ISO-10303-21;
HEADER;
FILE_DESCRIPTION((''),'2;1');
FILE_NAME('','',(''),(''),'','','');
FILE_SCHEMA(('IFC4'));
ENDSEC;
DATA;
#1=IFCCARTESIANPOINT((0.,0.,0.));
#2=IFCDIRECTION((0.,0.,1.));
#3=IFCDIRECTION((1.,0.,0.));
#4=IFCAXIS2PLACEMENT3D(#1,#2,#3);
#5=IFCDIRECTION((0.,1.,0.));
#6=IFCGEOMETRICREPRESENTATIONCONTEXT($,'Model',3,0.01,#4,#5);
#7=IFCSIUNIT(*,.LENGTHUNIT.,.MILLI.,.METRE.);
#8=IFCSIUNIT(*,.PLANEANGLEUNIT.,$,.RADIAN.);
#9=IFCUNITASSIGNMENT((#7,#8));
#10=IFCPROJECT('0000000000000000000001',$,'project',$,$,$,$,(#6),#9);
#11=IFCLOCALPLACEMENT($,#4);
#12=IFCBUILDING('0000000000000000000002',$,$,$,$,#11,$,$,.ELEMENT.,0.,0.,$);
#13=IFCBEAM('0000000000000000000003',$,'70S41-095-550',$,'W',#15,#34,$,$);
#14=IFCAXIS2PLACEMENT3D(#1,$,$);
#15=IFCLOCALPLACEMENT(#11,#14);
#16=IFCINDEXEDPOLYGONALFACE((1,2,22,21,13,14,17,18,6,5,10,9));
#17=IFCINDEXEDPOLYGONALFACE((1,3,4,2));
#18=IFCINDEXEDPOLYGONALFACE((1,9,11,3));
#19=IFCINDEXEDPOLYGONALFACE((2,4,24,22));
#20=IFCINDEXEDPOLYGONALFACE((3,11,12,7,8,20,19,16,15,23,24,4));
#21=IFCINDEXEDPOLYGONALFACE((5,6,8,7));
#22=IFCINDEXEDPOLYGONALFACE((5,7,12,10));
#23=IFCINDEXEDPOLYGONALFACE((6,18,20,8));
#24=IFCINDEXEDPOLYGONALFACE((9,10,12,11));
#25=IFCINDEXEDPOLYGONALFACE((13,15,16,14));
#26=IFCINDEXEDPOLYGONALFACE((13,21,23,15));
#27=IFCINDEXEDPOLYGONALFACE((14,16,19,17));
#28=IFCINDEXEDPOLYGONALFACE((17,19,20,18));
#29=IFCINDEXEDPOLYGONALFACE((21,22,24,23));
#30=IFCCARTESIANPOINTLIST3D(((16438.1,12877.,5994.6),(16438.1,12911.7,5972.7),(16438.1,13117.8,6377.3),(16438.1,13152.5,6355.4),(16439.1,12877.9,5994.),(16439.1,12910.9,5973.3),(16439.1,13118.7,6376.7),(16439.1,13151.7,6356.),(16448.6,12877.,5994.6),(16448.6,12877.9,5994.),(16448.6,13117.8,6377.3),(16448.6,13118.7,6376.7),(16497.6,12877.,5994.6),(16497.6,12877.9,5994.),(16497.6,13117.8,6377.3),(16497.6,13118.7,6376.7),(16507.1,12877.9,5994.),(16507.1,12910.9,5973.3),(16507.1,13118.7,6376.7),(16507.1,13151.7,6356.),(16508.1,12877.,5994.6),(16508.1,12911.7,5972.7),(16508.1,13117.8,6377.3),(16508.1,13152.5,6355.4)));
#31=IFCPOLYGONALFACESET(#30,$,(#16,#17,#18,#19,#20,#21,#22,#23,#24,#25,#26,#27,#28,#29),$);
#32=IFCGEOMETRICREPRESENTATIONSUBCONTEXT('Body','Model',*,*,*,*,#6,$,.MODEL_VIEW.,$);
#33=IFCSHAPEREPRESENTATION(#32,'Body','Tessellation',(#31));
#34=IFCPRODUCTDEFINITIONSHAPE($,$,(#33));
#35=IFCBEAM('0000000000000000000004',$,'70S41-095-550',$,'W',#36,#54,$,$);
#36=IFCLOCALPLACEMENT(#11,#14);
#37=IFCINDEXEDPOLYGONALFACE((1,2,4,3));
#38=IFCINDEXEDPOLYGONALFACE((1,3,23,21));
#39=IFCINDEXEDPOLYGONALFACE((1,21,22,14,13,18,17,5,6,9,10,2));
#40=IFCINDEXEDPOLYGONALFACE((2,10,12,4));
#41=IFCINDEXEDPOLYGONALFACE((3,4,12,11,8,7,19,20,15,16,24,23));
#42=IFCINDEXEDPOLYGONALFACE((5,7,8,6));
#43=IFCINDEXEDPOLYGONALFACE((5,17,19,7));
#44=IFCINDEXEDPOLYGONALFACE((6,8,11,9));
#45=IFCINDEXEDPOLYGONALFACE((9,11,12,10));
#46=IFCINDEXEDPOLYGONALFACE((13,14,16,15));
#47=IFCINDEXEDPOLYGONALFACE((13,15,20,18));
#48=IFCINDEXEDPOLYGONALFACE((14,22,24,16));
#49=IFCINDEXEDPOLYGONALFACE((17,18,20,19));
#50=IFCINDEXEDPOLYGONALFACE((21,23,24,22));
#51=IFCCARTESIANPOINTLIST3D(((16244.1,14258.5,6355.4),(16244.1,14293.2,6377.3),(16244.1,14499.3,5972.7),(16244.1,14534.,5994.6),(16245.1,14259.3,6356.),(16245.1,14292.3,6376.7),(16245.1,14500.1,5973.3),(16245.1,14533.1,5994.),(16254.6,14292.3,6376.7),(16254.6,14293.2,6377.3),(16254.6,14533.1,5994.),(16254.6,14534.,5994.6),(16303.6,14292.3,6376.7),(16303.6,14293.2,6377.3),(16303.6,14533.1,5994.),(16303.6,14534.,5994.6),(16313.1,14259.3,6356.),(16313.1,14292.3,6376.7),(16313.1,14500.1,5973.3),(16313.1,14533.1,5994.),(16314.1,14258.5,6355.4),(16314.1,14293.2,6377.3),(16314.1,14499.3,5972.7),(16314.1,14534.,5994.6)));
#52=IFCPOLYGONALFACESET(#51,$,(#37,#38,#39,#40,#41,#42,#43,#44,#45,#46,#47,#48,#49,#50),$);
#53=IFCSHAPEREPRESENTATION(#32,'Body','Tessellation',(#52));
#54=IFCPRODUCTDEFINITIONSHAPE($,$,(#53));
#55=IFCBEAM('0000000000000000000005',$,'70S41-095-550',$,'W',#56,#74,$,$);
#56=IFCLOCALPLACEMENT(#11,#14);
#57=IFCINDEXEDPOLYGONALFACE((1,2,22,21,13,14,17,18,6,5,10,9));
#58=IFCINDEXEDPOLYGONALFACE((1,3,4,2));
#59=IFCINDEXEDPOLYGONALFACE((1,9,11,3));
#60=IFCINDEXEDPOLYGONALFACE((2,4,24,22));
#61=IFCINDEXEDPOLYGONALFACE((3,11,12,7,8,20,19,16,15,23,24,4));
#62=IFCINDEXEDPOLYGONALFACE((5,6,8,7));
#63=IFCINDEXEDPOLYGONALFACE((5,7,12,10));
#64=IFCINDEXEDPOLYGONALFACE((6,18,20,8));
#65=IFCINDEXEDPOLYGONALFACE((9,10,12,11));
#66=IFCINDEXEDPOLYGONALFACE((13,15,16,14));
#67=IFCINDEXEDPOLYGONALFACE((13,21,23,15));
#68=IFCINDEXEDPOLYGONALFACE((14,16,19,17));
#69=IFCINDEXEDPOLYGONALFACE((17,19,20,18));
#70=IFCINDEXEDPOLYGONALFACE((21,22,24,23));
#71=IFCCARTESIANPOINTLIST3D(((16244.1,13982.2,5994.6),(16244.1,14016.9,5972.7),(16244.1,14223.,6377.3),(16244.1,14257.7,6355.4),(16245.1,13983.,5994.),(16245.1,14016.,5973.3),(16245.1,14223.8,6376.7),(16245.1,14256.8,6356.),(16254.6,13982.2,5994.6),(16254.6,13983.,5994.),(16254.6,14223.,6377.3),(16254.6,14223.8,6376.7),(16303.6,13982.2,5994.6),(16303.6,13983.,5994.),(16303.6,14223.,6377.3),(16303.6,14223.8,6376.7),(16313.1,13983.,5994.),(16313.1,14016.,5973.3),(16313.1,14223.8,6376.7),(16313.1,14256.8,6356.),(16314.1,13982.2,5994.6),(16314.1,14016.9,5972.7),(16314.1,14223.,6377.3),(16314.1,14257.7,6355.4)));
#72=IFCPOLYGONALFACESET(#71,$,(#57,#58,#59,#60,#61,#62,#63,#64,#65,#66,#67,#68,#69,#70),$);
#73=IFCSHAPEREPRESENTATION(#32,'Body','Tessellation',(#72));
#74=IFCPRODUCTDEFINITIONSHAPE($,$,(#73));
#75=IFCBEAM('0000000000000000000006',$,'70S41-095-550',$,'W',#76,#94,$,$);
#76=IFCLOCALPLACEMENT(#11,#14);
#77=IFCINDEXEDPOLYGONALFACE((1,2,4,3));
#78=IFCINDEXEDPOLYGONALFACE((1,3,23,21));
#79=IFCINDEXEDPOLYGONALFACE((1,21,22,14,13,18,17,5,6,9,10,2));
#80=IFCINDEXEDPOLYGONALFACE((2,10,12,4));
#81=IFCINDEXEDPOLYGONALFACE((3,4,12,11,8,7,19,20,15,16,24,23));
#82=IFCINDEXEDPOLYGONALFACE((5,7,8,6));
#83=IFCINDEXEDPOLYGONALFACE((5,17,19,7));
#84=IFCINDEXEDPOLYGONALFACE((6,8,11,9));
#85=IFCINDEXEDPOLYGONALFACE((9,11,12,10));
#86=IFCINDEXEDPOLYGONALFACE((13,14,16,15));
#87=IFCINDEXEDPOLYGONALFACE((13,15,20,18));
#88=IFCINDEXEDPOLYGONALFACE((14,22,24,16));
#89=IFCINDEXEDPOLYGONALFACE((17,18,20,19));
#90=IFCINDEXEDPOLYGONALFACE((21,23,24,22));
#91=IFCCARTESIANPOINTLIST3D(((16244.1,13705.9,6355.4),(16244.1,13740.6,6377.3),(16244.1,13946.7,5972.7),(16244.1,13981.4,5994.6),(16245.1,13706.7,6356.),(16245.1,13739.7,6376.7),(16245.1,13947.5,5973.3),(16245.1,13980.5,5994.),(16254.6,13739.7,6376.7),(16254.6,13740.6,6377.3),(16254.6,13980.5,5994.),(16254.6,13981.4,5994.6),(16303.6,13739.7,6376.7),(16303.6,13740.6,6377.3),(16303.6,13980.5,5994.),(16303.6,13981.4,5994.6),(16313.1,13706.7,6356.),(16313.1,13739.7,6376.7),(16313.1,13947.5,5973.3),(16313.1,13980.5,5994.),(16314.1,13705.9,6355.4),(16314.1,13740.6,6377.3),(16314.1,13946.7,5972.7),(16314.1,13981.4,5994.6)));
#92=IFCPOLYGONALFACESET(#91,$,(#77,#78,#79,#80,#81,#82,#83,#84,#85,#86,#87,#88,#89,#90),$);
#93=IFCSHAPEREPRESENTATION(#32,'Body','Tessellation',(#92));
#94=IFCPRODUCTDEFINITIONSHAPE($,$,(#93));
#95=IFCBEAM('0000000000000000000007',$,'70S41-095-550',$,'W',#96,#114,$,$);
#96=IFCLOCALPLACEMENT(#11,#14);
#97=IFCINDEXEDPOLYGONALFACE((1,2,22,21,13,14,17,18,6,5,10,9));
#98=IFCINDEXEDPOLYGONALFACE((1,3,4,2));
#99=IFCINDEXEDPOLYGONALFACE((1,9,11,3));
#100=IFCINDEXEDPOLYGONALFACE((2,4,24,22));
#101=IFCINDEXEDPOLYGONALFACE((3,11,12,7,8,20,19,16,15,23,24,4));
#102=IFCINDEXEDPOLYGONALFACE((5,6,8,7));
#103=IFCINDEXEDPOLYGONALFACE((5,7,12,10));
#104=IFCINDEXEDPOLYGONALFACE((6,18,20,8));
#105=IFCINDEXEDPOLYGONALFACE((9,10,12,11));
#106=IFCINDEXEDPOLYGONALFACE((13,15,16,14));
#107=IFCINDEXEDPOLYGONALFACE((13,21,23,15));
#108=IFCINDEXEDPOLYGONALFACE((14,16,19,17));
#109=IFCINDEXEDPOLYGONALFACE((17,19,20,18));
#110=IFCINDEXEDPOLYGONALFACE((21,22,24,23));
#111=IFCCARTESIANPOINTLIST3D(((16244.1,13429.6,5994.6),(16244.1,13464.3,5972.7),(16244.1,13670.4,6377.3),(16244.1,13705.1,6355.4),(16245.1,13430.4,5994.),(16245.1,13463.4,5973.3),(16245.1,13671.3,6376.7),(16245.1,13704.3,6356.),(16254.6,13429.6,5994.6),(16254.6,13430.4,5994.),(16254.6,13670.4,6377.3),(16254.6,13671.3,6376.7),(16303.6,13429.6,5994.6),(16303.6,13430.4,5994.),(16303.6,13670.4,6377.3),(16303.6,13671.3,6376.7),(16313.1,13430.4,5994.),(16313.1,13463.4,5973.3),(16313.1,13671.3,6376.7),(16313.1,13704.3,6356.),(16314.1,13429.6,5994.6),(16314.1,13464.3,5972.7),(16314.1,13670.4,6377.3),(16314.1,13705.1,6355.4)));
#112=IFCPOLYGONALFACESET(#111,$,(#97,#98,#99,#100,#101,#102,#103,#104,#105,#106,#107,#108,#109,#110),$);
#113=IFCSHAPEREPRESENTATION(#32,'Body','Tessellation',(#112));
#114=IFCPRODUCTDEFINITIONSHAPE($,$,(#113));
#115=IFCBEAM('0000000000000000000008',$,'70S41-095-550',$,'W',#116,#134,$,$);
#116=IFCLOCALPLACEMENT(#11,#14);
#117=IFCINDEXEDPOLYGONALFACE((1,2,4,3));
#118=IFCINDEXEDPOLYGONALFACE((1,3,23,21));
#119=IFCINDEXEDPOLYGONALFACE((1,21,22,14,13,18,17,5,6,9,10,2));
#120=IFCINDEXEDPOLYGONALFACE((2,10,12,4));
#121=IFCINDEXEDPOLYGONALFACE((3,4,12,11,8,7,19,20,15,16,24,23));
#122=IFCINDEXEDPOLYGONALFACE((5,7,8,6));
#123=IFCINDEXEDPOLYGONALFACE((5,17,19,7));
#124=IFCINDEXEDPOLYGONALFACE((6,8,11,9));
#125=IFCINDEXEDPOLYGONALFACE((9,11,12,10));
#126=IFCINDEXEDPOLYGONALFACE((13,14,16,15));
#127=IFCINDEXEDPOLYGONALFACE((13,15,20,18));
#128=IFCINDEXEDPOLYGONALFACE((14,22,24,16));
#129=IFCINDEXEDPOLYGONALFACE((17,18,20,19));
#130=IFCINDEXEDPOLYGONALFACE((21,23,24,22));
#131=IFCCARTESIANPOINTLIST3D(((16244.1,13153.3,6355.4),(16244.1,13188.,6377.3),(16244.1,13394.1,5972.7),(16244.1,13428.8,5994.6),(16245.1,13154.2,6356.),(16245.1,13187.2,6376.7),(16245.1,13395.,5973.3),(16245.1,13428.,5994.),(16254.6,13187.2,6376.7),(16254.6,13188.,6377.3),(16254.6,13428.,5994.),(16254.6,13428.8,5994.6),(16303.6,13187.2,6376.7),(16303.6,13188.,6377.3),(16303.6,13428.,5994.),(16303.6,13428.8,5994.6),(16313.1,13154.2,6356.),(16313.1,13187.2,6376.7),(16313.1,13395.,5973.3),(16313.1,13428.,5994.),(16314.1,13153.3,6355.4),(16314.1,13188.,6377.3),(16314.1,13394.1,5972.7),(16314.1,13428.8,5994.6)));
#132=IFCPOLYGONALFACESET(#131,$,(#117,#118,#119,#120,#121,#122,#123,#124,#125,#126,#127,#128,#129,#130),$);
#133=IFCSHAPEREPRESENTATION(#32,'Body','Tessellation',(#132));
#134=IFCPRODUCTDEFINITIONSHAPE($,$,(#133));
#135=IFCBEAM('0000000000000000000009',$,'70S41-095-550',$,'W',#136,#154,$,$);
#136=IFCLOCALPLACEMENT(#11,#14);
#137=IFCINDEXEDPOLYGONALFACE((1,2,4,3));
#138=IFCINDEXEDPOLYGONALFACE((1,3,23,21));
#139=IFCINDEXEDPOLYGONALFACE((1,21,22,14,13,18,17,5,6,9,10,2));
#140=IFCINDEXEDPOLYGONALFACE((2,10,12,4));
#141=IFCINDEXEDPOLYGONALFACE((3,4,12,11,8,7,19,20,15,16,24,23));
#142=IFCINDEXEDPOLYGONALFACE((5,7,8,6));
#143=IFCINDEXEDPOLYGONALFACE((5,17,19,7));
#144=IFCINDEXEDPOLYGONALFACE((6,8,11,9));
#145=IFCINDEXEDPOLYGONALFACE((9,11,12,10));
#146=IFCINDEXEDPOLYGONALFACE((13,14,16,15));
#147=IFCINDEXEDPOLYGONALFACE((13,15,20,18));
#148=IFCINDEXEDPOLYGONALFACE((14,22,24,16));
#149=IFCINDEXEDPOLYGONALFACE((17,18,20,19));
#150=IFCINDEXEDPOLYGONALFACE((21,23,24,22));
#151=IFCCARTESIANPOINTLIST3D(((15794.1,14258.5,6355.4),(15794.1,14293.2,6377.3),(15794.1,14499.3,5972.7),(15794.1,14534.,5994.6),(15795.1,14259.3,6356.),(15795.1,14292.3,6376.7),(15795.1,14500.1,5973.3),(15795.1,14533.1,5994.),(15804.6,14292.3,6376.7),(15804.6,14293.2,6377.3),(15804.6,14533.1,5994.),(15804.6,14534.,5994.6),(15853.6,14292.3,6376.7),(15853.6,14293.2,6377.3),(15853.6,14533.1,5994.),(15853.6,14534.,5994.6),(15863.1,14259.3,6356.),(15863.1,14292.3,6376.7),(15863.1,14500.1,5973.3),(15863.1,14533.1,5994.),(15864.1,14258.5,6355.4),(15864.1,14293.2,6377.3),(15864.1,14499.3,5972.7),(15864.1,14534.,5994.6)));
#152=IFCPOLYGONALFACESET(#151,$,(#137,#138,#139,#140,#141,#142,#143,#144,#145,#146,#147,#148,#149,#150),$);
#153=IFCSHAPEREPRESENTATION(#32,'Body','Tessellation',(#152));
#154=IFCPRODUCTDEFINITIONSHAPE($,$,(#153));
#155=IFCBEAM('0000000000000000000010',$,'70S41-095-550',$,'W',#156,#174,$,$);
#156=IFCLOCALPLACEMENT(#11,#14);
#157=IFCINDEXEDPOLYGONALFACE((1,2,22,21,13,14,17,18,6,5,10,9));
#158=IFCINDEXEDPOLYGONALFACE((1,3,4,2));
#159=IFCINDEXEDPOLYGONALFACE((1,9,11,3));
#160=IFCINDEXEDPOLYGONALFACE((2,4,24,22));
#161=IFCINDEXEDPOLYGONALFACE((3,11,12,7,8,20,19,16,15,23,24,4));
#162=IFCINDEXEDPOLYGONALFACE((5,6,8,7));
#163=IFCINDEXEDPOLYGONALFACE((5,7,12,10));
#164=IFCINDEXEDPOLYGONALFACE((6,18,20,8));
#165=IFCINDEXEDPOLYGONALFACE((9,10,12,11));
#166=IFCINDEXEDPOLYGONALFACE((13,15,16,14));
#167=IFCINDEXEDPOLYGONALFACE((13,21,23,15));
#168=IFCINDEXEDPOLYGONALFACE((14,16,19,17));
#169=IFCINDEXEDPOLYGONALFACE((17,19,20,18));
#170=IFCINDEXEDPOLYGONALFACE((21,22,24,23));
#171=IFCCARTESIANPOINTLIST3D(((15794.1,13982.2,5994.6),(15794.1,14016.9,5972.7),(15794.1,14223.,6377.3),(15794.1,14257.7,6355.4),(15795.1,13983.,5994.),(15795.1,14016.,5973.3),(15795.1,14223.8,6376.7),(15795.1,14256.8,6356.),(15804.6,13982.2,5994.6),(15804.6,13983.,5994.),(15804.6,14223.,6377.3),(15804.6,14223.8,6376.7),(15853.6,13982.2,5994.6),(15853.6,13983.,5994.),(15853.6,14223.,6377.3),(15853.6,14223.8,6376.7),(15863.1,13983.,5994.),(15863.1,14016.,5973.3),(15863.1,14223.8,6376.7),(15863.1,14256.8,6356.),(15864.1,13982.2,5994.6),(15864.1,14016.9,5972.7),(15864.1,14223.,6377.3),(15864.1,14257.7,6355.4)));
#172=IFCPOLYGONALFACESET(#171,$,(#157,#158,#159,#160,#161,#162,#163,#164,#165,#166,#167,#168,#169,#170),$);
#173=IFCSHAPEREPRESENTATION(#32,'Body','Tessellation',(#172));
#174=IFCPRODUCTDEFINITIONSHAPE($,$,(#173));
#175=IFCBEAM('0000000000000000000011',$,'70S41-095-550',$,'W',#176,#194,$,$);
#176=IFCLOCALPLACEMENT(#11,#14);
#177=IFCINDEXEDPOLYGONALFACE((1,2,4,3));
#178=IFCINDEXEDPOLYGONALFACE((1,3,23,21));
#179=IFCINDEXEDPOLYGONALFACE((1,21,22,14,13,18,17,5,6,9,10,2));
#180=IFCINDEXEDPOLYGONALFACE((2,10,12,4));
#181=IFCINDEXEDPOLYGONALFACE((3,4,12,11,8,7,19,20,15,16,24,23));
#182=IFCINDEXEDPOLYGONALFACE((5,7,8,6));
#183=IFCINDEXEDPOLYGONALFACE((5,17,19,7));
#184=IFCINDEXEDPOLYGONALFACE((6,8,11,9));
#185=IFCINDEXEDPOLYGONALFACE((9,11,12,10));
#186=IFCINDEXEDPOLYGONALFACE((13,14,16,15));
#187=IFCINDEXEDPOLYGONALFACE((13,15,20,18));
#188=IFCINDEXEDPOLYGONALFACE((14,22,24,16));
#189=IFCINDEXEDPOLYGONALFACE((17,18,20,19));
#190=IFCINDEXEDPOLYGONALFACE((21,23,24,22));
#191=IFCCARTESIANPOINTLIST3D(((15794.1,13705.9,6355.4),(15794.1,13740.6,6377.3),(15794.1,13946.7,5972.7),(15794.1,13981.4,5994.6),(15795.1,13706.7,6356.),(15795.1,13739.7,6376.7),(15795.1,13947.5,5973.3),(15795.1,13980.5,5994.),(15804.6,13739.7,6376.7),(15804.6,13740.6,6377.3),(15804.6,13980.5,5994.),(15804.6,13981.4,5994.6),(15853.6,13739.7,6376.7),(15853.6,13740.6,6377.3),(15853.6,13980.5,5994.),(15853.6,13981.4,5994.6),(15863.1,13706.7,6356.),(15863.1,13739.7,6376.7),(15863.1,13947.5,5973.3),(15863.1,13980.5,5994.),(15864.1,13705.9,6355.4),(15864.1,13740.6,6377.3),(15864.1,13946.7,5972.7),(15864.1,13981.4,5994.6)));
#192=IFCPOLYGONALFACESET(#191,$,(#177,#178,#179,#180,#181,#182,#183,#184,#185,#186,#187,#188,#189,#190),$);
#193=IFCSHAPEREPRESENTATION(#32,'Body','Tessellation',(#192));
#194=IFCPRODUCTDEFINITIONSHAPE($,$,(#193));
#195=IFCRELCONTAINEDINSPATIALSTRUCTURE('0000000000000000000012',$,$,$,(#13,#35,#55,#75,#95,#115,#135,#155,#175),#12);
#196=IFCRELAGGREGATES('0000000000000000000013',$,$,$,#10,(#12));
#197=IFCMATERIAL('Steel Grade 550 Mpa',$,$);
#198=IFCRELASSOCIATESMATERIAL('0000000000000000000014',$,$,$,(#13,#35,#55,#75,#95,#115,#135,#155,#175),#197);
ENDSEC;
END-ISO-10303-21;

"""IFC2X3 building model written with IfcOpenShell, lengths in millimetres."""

from ifc_helpers import new_model, si_unit, direction, frame, origin, origin_with_axes, origin_2d_with_axis, place, context, subcontext, project, spatial, c_section, extrude, source, transform, mapped, material, element, save


model = new_model("IFC2X3")

# Units and contexts
model_context = context("Model", 3, precision=0.01, world=origin_with_axes(), true_north=direction((0.0, 1.0, 0.0)))
body_context = subcontext(model_context, "Body", "Model", "MODEL_VIEW")
ifc_project = project(units=[si_unit("LENGTHUNIT", "METRE", prefix="MILLI"), si_unit("PLANEANGLEUNIT", "RADIAN")], contexts=[model_context])

# Building
building_placement = place(None, origin_with_axes())
building = spatial("IfcBuilding", under=ifc_project, at=building_placement, CompositionType="ELEMENT", ElevationOfRefHeight=0.0, ElevationOfTerrain=0.0)

# Shared definitions
ifc_material = material(Name="Steel Grade 550 Mpa")

# Beams
shared_shape_1 = source(origin(), body_context, "Body", "SweptSolid", [
    extrude(c_section(Depth=70.0, Width=41.0, WallThickness=1.0, Girth=10.5, at=origin_2d_with_axis()), origin_with_axes(), (0.0, 0.0, 1.0), 452.2),
])
beam_1_placement = place(None, frame((16473.1, 12894.4, 5983.7), z_axis=(0.0, 0.532581, 0.846379), x_axis=(0.0, -0.846379, 0.532581)))
element("IfcBeam", 1, at=beam_1_placement, inside=building, material=ifc_material, Name="70S41-095-550", ObjectType="W", context=body_context, shape_type="MappedRepresentation", body=[
    mapped(shared_shape_1, transform((0.0, 0.0, 0.0), scale=1.0)),
])
shared_shape_2 = source(origin(), body_context, "Body", "SweptSolid", [
    extrude(c_section(Depth=70.0, Width=41.0, WallThickness=1.0, Girth=10.5, at=origin_2d_with_axis()), origin_with_axes(), (0.0, 0.0, 1.0), 452.2),
])
beam_2_placement = place(None, frame((16279.1, 14275.8, 6366.3), z_axis=(0.0, 0.532581, -0.846379), x_axis=(0.0, 0.846379, 0.532581)))
element("IfcBeam", 2, at=beam_2_placement, inside=building, material=ifc_material, Name="70S41-095-550", ObjectType="W", context=body_context, shape_type="MappedRepresentation", body=[
    mapped(shared_shape_2, transform((0.0, 0.0, 0.0), scale=1.0)),
])
shared_shape_3 = source(origin(), body_context, "Body", "SweptSolid", [
    extrude(c_section(Depth=70.0, Width=41.0, WallThickness=1.0, Girth=10.5, at=origin_2d_with_axis()), origin_with_axes(), (0.0, 0.0, 1.0), 452.2),
])
beam_3_placement = place(None, frame((16279.1, 13999.5, 5983.7), z_axis=(0.0, 0.532581, 0.846379), x_axis=(0.0, -0.846379, 0.532581)))
element("IfcBeam", 3, at=beam_3_placement, inside=building, material=ifc_material, Name="70S41-095-550", ObjectType="W", context=body_context, shape_type="MappedRepresentation", body=[
    mapped(shared_shape_3, transform((0.0, 0.0, 0.0), scale=1.0)),
])
shared_shape_4 = source(origin(), body_context, "Body", "SweptSolid", [
    extrude(c_section(Depth=70.0, Width=41.0, WallThickness=1.0, Girth=10.5, at=origin_2d_with_axis()), origin_with_axes(), (0.0, 0.0, 1.0), 452.2),
])
beam_4_placement = place(None, frame((16279.1, 13723.2, 6366.3), z_axis=(0.0, 0.532581, -0.846379), x_axis=(0.0, 0.846379, 0.532581)))
element("IfcBeam", 4, at=beam_4_placement, inside=building, material=ifc_material, Name="70S41-095-550", ObjectType="W", context=body_context, shape_type="MappedRepresentation", body=[
    mapped(shared_shape_4, transform((0.0, 0.0, 0.0), scale=1.0)),
])
shared_shape_5 = source(origin(), body_context, "Body", "SweptSolid", [
    extrude(c_section(Depth=70.0, Width=41.0, WallThickness=1.0, Girth=10.5, at=origin_2d_with_axis()), origin_with_axes(), (0.0, 0.0, 1.0), 452.2),
])
beam_5_placement = place(None, frame((16279.1, 13446.9, 5983.7), z_axis=(0.0, 0.532581, 0.846379), x_axis=(0.0, -0.846379, 0.532581)))
element("IfcBeam", 5, at=beam_5_placement, inside=building, material=ifc_material, Name="70S41-095-550", ObjectType="W", context=body_context, shape_type="MappedRepresentation", body=[
    mapped(shared_shape_5, transform((0.0, 0.0, 0.0), scale=1.0)),
])
shared_shape_6 = source(origin(), body_context, "Body", "SweptSolid", [
    extrude(c_section(Depth=70.0, Width=41.0, WallThickness=1.0, Girth=10.5, at=origin_2d_with_axis()), origin_with_axes(), (0.0, 0.0, 1.0), 452.2),
])
beam_6_placement = place(None, frame((16279.1, 13170.7, 6366.3), z_axis=(0.0, 0.532581, -0.846379), x_axis=(0.0, 0.846379, 0.532581)))
element("IfcBeam", 6, at=beam_6_placement, inside=building, material=ifc_material, Name="70S41-095-550", ObjectType="W", context=body_context, shape_type="MappedRepresentation", body=[
    mapped(shared_shape_6, transform((0.0, 0.0, 0.0), scale=1.0)),
])
shared_shape_7 = source(origin(), body_context, "Body", "SweptSolid", [
    extrude(c_section(Depth=70.0, Width=41.0, WallThickness=1.0, Girth=10.5, at=origin_2d_with_axis()), origin_with_axes(), (0.0, 0.0, 1.0), 452.2),
])
beam_7_placement = place(None, frame((15829.1, 14275.8, 6366.3), z_axis=(0.0, 0.532581, -0.846379), x_axis=(0.0, 0.846379, 0.532581)))
element("IfcBeam", 7, at=beam_7_placement, inside=building, material=ifc_material, Name="70S41-095-550", ObjectType="W", context=body_context, shape_type="MappedRepresentation", body=[
    mapped(shared_shape_7, transform((0.0, 0.0, 0.0), scale=1.0)),
])
shared_shape_8 = source(origin(), body_context, "Body", "SweptSolid", [
    extrude(c_section(Depth=70.0, Width=41.0, WallThickness=1.0, Girth=10.5, at=origin_2d_with_axis()), origin_with_axes(), (0.0, 0.0, 1.0), 452.2),
])
beam_8_placement = place(None, frame((15829.1, 13999.5, 5983.7), z_axis=(0.0, 0.532581, 0.846379), x_axis=(0.0, -0.846379, 0.532581)))
element("IfcBeam", 8, at=beam_8_placement, inside=building, material=ifc_material, Name="70S41-095-550", ObjectType="W", context=body_context, shape_type="MappedRepresentation", body=[
    mapped(shared_shape_8, transform((0.0, 0.0, 0.0), scale=1.0)),
])
shared_shape_9 = source(origin(), body_context, "Body", "SweptSolid", [
    extrude(c_section(Depth=70.0, Width=41.0, WallThickness=1.0, Girth=10.5, at=origin_2d_with_axis()), origin_with_axes(), (0.0, 0.0, 1.0), 452.2),
])
beam_9_placement = place(None, frame((15829.1, 13723.2, 6366.3), z_axis=(0.0, 0.532581, -0.846379), x_axis=(0.0, 0.846379, 0.532581)))
element("IfcBeam", 9, at=beam_9_placement, inside=building, material=ifc_material, Name="70S41-095-550", ObjectType="W", context=body_context, shape_type="MappedRepresentation", body=[
    mapped(shared_shape_9, transform((0.0, 0.0, 0.0), scale=1.0)),
])

save(model, "model.ifc")
